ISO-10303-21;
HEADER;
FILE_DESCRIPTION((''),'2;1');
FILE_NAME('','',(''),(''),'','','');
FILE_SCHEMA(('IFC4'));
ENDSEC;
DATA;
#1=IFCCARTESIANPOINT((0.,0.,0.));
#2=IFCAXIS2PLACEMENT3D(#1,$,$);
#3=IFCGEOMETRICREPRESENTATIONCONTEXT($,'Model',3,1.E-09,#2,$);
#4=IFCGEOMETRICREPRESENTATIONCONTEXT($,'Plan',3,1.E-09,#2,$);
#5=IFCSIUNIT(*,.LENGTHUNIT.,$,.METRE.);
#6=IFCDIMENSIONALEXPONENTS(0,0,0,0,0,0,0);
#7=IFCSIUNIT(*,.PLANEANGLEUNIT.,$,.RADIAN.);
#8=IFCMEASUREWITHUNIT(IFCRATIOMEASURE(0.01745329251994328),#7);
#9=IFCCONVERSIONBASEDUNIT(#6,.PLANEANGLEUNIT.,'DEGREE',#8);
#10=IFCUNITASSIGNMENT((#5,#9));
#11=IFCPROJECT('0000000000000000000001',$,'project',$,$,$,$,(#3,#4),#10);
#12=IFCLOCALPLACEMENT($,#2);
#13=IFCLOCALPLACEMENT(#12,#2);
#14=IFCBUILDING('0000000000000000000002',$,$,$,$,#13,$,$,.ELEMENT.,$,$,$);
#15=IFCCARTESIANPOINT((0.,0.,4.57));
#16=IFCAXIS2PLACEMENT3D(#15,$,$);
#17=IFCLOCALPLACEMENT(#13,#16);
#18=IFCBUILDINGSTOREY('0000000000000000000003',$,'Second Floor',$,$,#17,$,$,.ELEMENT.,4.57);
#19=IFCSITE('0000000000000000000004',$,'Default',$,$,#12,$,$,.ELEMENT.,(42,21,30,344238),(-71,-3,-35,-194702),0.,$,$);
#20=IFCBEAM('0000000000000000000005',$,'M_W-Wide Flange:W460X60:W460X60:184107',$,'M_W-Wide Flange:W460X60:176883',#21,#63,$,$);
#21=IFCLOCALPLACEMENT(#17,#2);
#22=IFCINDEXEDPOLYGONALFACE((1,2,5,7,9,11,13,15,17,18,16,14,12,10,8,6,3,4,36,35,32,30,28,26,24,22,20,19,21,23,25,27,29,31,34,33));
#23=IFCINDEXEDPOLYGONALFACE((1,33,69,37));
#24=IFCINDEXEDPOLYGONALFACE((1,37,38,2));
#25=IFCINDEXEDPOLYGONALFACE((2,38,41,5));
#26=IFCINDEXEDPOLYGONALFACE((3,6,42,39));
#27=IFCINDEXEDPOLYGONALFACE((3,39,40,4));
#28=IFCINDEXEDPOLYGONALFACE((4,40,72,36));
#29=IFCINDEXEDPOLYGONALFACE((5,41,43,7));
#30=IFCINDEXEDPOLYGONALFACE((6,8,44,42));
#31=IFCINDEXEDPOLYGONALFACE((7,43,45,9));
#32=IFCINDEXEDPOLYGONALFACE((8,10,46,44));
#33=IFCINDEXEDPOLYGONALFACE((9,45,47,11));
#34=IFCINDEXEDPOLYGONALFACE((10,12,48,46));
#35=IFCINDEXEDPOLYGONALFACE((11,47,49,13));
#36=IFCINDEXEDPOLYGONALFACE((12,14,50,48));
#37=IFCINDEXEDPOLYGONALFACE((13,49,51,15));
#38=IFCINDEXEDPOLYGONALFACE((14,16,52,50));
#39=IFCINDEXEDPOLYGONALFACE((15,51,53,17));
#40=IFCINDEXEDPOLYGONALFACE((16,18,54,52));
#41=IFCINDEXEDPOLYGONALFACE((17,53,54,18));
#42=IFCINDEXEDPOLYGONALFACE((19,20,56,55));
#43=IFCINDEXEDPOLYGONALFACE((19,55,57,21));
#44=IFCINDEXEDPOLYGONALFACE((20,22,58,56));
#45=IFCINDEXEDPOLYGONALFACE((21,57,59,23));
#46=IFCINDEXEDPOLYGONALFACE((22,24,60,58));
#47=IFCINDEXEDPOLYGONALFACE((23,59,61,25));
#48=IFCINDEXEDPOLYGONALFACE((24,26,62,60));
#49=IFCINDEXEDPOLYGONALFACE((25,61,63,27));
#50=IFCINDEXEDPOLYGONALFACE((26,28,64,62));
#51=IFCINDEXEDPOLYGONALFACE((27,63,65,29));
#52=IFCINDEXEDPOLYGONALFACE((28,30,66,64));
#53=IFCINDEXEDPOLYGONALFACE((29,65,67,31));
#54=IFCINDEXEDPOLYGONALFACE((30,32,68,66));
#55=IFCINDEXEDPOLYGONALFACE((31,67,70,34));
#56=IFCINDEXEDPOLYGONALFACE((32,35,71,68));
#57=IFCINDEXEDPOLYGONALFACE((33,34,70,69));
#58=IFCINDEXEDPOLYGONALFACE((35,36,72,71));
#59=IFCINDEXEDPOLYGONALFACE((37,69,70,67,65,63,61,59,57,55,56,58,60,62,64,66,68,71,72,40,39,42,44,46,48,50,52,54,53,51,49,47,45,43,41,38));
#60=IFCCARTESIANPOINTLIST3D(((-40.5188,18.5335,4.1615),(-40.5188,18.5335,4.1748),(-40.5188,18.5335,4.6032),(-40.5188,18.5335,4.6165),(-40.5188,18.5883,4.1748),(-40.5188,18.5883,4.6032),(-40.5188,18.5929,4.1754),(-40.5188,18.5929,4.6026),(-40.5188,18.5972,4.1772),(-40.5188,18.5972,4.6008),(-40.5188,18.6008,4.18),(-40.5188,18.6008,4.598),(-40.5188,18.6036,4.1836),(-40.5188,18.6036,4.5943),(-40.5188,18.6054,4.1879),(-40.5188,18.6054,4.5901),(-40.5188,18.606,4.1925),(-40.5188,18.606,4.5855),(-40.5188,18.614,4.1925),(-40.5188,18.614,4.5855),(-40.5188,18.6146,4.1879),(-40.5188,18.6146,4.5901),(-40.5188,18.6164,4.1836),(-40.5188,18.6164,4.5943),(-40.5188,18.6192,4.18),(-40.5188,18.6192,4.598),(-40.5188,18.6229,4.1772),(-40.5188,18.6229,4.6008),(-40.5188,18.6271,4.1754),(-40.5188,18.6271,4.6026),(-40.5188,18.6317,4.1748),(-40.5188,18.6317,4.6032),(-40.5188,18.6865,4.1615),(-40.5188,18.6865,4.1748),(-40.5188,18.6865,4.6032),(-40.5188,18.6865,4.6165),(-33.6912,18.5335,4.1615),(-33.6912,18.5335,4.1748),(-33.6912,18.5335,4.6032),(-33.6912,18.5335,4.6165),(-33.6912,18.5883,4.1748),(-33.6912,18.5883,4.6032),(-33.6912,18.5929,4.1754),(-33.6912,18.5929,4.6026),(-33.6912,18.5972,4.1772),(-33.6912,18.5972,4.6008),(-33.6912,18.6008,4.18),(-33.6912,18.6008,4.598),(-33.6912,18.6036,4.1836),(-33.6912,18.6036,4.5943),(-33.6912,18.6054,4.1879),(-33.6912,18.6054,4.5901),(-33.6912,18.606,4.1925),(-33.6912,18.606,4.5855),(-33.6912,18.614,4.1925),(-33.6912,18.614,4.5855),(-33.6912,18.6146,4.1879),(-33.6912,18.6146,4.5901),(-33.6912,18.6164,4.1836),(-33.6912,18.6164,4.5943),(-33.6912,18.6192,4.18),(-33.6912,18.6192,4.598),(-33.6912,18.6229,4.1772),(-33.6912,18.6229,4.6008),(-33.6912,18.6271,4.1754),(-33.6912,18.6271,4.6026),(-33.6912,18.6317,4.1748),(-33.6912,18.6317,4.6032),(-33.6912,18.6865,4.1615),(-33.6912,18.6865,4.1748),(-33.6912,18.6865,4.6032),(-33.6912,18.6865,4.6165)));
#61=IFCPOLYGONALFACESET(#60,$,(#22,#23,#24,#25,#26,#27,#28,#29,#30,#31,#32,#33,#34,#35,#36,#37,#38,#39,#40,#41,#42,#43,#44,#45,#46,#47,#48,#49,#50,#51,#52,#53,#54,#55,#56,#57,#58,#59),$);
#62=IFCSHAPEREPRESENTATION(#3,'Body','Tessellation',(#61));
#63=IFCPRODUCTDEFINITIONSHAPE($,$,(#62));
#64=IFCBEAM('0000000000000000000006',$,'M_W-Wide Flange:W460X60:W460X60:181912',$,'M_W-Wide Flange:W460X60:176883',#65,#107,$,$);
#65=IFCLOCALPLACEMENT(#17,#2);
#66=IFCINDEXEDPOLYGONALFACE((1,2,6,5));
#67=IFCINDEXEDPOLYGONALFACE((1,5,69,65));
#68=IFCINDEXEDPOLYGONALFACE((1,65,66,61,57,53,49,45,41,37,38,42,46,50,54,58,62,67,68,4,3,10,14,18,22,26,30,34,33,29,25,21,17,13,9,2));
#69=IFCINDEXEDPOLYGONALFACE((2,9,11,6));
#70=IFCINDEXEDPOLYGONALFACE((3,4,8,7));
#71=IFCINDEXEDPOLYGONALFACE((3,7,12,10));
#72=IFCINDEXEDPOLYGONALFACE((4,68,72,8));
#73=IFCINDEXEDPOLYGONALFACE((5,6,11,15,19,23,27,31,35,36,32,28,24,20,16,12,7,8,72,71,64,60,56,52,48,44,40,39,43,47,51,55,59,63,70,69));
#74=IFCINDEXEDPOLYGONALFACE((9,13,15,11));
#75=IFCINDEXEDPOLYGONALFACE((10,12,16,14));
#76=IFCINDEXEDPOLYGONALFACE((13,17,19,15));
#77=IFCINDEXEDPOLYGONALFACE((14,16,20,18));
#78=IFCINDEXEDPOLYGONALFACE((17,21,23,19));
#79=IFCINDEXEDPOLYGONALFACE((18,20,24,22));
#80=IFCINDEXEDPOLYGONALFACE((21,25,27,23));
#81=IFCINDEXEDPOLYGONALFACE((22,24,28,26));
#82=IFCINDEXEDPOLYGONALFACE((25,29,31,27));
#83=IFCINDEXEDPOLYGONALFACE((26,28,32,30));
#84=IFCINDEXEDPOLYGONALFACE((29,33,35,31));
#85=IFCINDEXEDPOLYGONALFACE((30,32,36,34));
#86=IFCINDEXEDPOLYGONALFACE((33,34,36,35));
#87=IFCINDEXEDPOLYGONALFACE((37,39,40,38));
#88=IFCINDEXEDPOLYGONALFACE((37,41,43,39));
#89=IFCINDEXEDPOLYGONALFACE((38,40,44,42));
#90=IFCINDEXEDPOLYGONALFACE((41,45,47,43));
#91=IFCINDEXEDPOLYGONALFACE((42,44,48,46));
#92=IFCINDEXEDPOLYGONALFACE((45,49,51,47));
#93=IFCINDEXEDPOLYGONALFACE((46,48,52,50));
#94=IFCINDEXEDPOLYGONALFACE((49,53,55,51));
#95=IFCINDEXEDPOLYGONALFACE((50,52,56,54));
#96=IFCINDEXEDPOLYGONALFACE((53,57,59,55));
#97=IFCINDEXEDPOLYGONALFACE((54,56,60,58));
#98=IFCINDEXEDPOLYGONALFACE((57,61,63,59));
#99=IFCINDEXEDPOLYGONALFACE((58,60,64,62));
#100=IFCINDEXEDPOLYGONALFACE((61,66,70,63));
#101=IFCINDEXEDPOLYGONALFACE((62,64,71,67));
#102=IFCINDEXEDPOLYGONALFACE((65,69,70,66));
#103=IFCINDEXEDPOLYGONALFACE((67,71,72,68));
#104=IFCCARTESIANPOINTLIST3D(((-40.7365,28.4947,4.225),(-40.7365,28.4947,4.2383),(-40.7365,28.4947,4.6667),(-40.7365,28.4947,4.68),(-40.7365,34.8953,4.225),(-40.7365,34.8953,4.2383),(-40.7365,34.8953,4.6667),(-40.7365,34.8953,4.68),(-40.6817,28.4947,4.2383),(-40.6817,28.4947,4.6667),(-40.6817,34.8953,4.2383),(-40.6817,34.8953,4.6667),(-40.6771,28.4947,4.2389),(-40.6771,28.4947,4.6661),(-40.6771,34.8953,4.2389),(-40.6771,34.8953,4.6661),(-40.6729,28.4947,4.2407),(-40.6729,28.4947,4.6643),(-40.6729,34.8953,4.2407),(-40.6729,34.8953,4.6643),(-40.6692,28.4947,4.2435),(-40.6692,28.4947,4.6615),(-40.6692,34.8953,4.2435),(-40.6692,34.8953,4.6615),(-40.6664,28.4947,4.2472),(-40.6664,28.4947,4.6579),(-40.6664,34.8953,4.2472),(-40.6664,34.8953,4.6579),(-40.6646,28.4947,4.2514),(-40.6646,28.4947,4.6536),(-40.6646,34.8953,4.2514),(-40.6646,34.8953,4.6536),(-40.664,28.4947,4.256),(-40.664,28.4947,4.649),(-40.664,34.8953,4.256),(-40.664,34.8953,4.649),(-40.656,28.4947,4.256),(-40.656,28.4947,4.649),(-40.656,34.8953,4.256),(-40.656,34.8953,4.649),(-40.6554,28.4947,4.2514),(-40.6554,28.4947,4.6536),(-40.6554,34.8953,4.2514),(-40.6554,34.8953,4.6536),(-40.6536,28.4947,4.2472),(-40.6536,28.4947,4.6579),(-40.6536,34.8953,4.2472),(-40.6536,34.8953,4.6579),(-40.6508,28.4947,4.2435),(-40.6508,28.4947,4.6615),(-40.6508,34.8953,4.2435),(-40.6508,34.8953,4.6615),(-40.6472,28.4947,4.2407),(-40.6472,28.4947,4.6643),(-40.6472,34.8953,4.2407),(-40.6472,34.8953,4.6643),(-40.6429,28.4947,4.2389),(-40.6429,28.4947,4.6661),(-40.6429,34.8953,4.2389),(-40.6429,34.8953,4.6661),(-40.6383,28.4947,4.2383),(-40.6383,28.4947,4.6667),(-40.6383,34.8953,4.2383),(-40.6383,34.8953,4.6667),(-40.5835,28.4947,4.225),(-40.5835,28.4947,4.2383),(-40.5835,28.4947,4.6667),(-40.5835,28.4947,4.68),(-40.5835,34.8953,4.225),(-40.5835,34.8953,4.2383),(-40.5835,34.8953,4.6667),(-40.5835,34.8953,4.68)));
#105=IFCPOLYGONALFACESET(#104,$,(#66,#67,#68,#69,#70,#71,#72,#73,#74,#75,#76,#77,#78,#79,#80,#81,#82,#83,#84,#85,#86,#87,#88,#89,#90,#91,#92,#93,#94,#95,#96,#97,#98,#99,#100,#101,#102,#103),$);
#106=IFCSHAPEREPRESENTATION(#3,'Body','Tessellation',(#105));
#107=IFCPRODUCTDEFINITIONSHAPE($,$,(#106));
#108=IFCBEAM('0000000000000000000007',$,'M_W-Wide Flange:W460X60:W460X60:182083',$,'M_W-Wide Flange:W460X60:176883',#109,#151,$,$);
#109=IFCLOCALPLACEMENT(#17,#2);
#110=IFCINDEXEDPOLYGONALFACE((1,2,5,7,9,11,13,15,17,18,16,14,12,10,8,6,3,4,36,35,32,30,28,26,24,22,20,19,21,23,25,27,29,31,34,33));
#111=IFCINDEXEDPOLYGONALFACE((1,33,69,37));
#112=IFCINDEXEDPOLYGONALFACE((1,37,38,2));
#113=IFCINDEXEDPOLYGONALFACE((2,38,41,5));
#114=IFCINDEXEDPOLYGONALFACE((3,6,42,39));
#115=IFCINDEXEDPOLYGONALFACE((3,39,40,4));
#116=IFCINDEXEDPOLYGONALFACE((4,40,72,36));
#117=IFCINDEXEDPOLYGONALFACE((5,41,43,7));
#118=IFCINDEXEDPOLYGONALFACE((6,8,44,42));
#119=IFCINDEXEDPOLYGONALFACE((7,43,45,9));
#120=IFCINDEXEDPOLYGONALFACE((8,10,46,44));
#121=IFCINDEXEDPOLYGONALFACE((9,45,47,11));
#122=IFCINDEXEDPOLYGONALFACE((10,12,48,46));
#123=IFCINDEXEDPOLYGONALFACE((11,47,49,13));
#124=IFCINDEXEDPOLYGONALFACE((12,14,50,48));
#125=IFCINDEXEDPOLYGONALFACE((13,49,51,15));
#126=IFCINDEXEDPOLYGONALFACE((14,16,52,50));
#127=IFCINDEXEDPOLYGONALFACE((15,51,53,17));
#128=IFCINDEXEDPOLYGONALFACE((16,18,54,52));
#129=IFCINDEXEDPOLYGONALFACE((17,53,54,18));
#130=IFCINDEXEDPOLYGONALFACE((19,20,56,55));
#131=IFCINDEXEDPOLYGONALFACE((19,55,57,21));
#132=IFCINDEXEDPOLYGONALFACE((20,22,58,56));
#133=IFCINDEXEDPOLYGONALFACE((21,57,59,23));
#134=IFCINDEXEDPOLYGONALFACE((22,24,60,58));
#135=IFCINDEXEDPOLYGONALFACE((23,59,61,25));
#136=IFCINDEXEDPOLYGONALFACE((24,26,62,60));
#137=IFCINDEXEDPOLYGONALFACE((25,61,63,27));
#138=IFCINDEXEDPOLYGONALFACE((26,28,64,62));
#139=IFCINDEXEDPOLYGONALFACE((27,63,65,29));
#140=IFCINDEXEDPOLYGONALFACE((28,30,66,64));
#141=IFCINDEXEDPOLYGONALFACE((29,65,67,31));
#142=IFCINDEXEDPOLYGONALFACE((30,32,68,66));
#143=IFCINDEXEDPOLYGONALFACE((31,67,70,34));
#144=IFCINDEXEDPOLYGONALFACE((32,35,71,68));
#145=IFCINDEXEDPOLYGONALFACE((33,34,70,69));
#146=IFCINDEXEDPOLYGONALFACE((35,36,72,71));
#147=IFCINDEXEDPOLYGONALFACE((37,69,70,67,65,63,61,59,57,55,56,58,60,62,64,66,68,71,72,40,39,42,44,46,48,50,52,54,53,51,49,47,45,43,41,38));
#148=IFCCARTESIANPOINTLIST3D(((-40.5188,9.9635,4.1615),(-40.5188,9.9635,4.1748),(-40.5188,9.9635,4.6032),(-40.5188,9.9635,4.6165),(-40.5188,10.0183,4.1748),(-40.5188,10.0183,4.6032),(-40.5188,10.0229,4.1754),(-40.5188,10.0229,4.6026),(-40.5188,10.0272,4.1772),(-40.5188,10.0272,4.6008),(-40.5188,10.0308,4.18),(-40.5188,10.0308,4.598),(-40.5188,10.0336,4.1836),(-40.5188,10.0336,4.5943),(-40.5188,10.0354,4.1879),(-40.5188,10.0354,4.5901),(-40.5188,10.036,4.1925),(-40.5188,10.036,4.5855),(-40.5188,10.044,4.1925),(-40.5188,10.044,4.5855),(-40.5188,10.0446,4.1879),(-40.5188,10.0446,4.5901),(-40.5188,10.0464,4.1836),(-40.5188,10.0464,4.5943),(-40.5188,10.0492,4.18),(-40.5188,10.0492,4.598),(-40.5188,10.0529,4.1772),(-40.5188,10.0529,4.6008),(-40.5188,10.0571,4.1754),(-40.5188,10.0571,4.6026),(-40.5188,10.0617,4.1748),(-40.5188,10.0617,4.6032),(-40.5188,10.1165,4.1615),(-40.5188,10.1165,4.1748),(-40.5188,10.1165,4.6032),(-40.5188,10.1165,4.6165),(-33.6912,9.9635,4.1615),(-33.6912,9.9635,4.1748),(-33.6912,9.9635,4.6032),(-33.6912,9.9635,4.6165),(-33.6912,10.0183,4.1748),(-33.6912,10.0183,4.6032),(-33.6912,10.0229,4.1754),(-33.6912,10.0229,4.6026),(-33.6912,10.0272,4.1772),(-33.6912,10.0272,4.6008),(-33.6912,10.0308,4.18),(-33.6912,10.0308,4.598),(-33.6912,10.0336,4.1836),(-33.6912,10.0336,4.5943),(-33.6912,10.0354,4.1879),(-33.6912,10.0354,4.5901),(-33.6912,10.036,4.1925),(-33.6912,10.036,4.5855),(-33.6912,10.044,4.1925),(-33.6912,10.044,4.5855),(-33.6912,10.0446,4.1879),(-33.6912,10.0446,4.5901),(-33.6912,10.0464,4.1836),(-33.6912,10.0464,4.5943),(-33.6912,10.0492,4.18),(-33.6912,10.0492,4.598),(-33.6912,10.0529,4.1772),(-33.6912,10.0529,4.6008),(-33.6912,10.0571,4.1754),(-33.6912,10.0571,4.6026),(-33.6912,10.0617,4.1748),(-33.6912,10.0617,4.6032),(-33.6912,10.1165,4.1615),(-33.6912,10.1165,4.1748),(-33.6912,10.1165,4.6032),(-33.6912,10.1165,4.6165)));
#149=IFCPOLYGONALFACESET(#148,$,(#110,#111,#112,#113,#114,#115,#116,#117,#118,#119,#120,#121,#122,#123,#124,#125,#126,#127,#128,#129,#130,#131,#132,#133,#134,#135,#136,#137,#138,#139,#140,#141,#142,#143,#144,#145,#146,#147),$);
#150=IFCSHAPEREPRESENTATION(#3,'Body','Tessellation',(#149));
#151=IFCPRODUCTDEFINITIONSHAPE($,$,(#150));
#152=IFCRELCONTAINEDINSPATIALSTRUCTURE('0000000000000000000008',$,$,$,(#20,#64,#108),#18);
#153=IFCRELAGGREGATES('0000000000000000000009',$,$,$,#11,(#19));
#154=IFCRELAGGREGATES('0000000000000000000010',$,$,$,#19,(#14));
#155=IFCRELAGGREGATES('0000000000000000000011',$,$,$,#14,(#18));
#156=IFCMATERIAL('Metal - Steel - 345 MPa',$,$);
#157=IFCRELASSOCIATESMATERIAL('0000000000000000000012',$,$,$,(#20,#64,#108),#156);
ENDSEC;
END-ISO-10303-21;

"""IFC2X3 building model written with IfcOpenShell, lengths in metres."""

from ifc_helpers import new_model, entity, si_unit, converted_unit, frame, frame_2d, origin, place, context, project, spatial, polyline, circle_curve, parameter, trimmed, segment, composite_curve, outline, extrude, material, element, save


model = new_model("IFC2X3")

# Units and contexts
model_context = context("Model", 3, precision=1e-09, world=origin())
plan_context = context("Plan", 3, precision=1e-09, world=origin())
ifc_project = project(units=[si_unit("LENGTHUNIT", "METRE"), converted_unit("PLANEANGLEUNIT", "DEGREE", entity("IfcRatioMeasure", 0.01745329251994328), si_unit("PLANEANGLEUNIT", "RADIAN"), dimensions=[0, 0, 0, 0, 0, 0, 0])], contexts=[model_context, plan_context])

# Site, building, storey
site_placement = place(None, origin())
site = spatial("IfcSite", under=ifc_project, at=site_placement, Name="Default", CompositionType="ELEMENT", RefLatitude=(42, 21, 30, 344238), RefLongitude=(-71, -3, -35, -194702), RefElevation=0.0)
building_placement = place(site_placement, origin())
building = spatial("IfcBuilding", under=site, at=building_placement, CompositionType="ELEMENT")
storey_placement = place(building_placement, frame((0.0, 0.0, 4.57)))
storey = spatial("IfcBuildingStorey", under=building, at=storey_placement, Name="Second Floor", CompositionType="ELEMENT", Elevation=4.57)

# Shared definitions
ifc_material_1 = material(Name="Metal - Steel - 345 MPa")

# Beams
beam_1_placement = place(storey_placement, frame((-33.5527, 18.61, 4.6165), z_axis=(0.0, 0.0, 1.0), x_axis=(0.0, 1.0, 0.0)))
element("IfcBeam", 1, at=beam_1_placement, inside=storey, material=ifc_material_1, Name="M_W-Wide Flange:W460X60:W460X60:184107", ObjectType="M_W-Wide Flange:W460X60:176883", context=model_context, shape_type="SweptSolid", body=[
    extrude(outline(composite_curve([segment(polyline([(0.2142, -0.0765), (0.2275, -0.0765)]), True, "CONTINUOUS"), segment(polyline([(0.2275, -0.0765), (0.2275, 0.0765)]), True, "CONTINUOUS"), segment(polyline([(0.2275, 0.0765), (0.2142, 0.0765)]), True, "CONTINUOUS"), segment(polyline([(0.2142, 0.0765), (0.2142, 0.0217)]), True, "CONTINUOUS"), segment(trimmed(circle_curve(frame_2d((0.1965, 0.0217), x_axis=(1.0, 0.0)), 0.0177), [parameter(270.0)], [parameter(360.0)], True, "PARAMETER"), False, "CONTINUOUS"), segment(polyline([(0.1965, 0.004), (-0.1965, 0.004)]), True, "CONTINUOUS"), segment(trimmed(circle_curve(frame_2d((-0.1965, 0.0217), x_axis=(0.0, -1.0)), 0.0177), [parameter(270.0)], [parameter(360.0)], True, "PARAMETER"), False, "CONTINUOUS"), segment(polyline([(-0.2142, 0.0217), (-0.2142, 0.0765)]), True, "CONTINUOUS"), segment(polyline([(-0.2142, 0.0765), (-0.2275, 0.0765)]), True, "CONTINUOUS"), segment(polyline([(-0.2275, 0.0765), (-0.2275, -0.0765)]), True, "CONTINUOUS"), segment(polyline([(-0.2275, -0.0765), (-0.2142, -0.0765)]), True, "CONTINUOUS"), segment(polyline([(-0.2142, -0.0765), (-0.2142, -0.0217)]), True, "CONTINUOUS"), segment(trimmed(circle_curve(frame_2d((-0.1965, -0.0217), x_axis=(-1.0, 0.0)), 0.0177), [parameter(270.0)], [parameter(360.0)], True, "PARAMETER"), False, "CONTINUOUS"), segment(polyline([(-0.1965, -0.004), (0.1965, -0.004)]), True, "CONTINUOUS"), segment(trimmed(circle_curve(frame_2d((0.1965, -0.0217), x_axis=(0.0, 1.0)), 0.0177), [parameter(270.0)], [parameter(0.0)], True, "PARAMETER"), False, "CONTINUOUS"), segment(polyline([(0.2142, -0.0217), (0.2142, -0.0765)]), True, "CONTINUOUS")], self_intersect=False)), frame((0.0, 6.9661, -0.2275), z_axis=(0.0, -1.0, 0.0), x_axis=(0.0, 0.0, -1.0)), (0.0, 0.0, 1.0), 6.8276),
])
beam_2_placement = place(storey_placement, frame((-40.66, 28.3828, 4.68)))
element("IfcBeam", 2, at=beam_2_placement, inside=storey, material=ifc_material_1, Name="M_W-Wide Flange:W460X60:W460X60:181912", ObjectType="M_W-Wide Flange:W460X60:176883", context=model_context, shape_type="SweptSolid", body=[
    extrude(outline(composite_curve([segment(polyline([(-0.0765, -0.2142), (-0.0765, -0.2275)]), True, "CONTINUOUS"), segment(polyline([(-0.0765, -0.2275), (0.0765, -0.2275)]), True, "CONTINUOUS"), segment(polyline([(0.0765, -0.2275), (0.0765, -0.2142)]), True, "CONTINUOUS"), segment(polyline([(0.0765, -0.2142), (0.0217, -0.2142)]), True, "CONTINUOUS"), segment(trimmed(circle_curve(frame_2d((0.0217, -0.1965), x_axis=(0.0, -1.0)), 0.0177), [parameter(270.0)], [parameter(360.0)], True, "PARAMETER"), False, "CONTINUOUS"), segment(polyline([(0.004, -0.1965), (0.004, 0.1965)]), True, "CONTINUOUS"), segment(trimmed(circle_curve(frame_2d((0.0217, 0.1965), x_axis=(-1.0, 0.0)), 0.0177), [parameter(270.0)], [parameter(360.0)], True, "PARAMETER"), False, "CONTINUOUS"), segment(polyline([(0.0217, 0.2142), (0.0765, 0.2142)]), True, "CONTINUOUS"), segment(polyline([(0.0765, 0.2142), (0.0765, 0.2275)]), True, "CONTINUOUS"), segment(polyline([(0.0765, 0.2275), (-0.0765, 0.2275)]), True, "CONTINUOUS"), segment(polyline([(-0.0765, 0.2275), (-0.0765, 0.2142)]), True, "CONTINUOUS"), segment(polyline([(-0.0765, 0.2142), (-0.0217, 0.2142)]), True, "CONTINUOUS"), segment(trimmed(circle_curve(frame_2d((-0.0217, 0.1965), x_axis=(0.0, 1.0)), 0.0177), [parameter(270.0)], [parameter(360.0)], True, "PARAMETER"), False, "CONTINUOUS"), segment(polyline([(-0.004, 0.1965), (-0.004, -0.1965)]), True, "CONTINUOUS"), segment(trimmed(circle_curve(frame_2d((-0.0217, -0.1965), x_axis=(1.0, 0.0)), 0.0177), [parameter(270.0)], [parameter(0.0)], True, "PARAMETER"), False, "CONTINUOUS"), segment(polyline([(-0.0217, -0.2142), (-0.0765, -0.2142)]), True, "CONTINUOUS")], self_intersect=False)), frame((0.0, 0.1119, -0.2275), z_axis=(0.0, -1.0, 0.0), x_axis=(1.0, 0.0, 0.0)), (0.0, 0.0, -1.0), 6.4006),
])
beam_3_placement = place(storey_placement, frame((-40.6573, 10.04, 4.6165), z_axis=(0.0, 0.0, 1.0), x_axis=(0.0, -1.0, 0.0)))
element("IfcBeam", 3, at=beam_3_placement, inside=storey, material=ifc_material_1, Name="M_W-Wide Flange:W460X60:W460X60:182083", ObjectType="M_W-Wide Flange:W460X60:176883", context=model_context, shape_type="SweptSolid", body=[
    extrude(outline(composite_curve([segment(polyline([(-0.0765, -0.2142), (-0.0765, -0.2275)]), True, "CONTINUOUS"), segment(polyline([(-0.0765, -0.2275), (0.0765, -0.2275)]), True, "CONTINUOUS"), segment(polyline([(0.0765, -0.2275), (0.0765, -0.2142)]), True, "CONTINUOUS"), segment(polyline([(0.0765, -0.2142), (0.0217, -0.2142)]), True, "CONTINUOUS"), segment(trimmed(circle_curve(frame_2d((0.0217, -0.1965), x_axis=(0.0, -1.0)), 0.0177), [parameter(270.0)], [parameter(360.0)], True, "PARAMETER"), False, "CONTINUOUS"), segment(polyline([(0.004, -0.1965), (0.004, 0.1965)]), True, "CONTINUOUS"), segment(trimmed(circle_curve(frame_2d((0.0217, 0.1965), x_axis=(-1.0, 0.0)), 0.0177), [parameter(270.0)], [parameter(360.0)], True, "PARAMETER"), False, "CONTINUOUS"), segment(polyline([(0.0217, 0.2142), (0.0765, 0.2142)]), True, "CONTINUOUS"), segment(polyline([(0.0765, 0.2142), (0.0765, 0.2275)]), True, "CONTINUOUS"), segment(polyline([(0.0765, 0.2275), (-0.0765, 0.2275)]), True, "CONTINUOUS"), segment(polyline([(-0.0765, 0.2275), (-0.0765, 0.2142)]), True, "CONTINUOUS"), segment(polyline([(-0.0765, 0.2142), (-0.0217, 0.2142)]), True, "CONTINUOUS"), segment(trimmed(circle_curve(frame_2d((-0.0217, 0.1965), x_axis=(0.0, 1.0)), 0.0177), [parameter(270.0)], [parameter(360.0)], True, "PARAMETER"), False, "CONTINUOUS"), segment(polyline([(-0.004, 0.1965), (-0.004, -0.1965)]), True, "CONTINUOUS"), segment(trimmed(circle_curve(frame_2d((-0.0217, -0.1965), x_axis=(1.0, 0.0)), 0.0177), [parameter(270.0)], [parameter(0.0)], True, "PARAMETER"), False, "CONTINUOUS"), segment(polyline([(-0.0217, -0.2142), (-0.0765, -0.2142)]), True, "CONTINUOUS")], self_intersect=False)), frame((0.0, 0.1385, -0.2275), z_axis=(0.0, -1.0, 0.0), x_axis=(1.0, 0.0, 0.0)), (0.0, 0.0, -1.0), 6.8276),
])

save(model, "model.ifc")
